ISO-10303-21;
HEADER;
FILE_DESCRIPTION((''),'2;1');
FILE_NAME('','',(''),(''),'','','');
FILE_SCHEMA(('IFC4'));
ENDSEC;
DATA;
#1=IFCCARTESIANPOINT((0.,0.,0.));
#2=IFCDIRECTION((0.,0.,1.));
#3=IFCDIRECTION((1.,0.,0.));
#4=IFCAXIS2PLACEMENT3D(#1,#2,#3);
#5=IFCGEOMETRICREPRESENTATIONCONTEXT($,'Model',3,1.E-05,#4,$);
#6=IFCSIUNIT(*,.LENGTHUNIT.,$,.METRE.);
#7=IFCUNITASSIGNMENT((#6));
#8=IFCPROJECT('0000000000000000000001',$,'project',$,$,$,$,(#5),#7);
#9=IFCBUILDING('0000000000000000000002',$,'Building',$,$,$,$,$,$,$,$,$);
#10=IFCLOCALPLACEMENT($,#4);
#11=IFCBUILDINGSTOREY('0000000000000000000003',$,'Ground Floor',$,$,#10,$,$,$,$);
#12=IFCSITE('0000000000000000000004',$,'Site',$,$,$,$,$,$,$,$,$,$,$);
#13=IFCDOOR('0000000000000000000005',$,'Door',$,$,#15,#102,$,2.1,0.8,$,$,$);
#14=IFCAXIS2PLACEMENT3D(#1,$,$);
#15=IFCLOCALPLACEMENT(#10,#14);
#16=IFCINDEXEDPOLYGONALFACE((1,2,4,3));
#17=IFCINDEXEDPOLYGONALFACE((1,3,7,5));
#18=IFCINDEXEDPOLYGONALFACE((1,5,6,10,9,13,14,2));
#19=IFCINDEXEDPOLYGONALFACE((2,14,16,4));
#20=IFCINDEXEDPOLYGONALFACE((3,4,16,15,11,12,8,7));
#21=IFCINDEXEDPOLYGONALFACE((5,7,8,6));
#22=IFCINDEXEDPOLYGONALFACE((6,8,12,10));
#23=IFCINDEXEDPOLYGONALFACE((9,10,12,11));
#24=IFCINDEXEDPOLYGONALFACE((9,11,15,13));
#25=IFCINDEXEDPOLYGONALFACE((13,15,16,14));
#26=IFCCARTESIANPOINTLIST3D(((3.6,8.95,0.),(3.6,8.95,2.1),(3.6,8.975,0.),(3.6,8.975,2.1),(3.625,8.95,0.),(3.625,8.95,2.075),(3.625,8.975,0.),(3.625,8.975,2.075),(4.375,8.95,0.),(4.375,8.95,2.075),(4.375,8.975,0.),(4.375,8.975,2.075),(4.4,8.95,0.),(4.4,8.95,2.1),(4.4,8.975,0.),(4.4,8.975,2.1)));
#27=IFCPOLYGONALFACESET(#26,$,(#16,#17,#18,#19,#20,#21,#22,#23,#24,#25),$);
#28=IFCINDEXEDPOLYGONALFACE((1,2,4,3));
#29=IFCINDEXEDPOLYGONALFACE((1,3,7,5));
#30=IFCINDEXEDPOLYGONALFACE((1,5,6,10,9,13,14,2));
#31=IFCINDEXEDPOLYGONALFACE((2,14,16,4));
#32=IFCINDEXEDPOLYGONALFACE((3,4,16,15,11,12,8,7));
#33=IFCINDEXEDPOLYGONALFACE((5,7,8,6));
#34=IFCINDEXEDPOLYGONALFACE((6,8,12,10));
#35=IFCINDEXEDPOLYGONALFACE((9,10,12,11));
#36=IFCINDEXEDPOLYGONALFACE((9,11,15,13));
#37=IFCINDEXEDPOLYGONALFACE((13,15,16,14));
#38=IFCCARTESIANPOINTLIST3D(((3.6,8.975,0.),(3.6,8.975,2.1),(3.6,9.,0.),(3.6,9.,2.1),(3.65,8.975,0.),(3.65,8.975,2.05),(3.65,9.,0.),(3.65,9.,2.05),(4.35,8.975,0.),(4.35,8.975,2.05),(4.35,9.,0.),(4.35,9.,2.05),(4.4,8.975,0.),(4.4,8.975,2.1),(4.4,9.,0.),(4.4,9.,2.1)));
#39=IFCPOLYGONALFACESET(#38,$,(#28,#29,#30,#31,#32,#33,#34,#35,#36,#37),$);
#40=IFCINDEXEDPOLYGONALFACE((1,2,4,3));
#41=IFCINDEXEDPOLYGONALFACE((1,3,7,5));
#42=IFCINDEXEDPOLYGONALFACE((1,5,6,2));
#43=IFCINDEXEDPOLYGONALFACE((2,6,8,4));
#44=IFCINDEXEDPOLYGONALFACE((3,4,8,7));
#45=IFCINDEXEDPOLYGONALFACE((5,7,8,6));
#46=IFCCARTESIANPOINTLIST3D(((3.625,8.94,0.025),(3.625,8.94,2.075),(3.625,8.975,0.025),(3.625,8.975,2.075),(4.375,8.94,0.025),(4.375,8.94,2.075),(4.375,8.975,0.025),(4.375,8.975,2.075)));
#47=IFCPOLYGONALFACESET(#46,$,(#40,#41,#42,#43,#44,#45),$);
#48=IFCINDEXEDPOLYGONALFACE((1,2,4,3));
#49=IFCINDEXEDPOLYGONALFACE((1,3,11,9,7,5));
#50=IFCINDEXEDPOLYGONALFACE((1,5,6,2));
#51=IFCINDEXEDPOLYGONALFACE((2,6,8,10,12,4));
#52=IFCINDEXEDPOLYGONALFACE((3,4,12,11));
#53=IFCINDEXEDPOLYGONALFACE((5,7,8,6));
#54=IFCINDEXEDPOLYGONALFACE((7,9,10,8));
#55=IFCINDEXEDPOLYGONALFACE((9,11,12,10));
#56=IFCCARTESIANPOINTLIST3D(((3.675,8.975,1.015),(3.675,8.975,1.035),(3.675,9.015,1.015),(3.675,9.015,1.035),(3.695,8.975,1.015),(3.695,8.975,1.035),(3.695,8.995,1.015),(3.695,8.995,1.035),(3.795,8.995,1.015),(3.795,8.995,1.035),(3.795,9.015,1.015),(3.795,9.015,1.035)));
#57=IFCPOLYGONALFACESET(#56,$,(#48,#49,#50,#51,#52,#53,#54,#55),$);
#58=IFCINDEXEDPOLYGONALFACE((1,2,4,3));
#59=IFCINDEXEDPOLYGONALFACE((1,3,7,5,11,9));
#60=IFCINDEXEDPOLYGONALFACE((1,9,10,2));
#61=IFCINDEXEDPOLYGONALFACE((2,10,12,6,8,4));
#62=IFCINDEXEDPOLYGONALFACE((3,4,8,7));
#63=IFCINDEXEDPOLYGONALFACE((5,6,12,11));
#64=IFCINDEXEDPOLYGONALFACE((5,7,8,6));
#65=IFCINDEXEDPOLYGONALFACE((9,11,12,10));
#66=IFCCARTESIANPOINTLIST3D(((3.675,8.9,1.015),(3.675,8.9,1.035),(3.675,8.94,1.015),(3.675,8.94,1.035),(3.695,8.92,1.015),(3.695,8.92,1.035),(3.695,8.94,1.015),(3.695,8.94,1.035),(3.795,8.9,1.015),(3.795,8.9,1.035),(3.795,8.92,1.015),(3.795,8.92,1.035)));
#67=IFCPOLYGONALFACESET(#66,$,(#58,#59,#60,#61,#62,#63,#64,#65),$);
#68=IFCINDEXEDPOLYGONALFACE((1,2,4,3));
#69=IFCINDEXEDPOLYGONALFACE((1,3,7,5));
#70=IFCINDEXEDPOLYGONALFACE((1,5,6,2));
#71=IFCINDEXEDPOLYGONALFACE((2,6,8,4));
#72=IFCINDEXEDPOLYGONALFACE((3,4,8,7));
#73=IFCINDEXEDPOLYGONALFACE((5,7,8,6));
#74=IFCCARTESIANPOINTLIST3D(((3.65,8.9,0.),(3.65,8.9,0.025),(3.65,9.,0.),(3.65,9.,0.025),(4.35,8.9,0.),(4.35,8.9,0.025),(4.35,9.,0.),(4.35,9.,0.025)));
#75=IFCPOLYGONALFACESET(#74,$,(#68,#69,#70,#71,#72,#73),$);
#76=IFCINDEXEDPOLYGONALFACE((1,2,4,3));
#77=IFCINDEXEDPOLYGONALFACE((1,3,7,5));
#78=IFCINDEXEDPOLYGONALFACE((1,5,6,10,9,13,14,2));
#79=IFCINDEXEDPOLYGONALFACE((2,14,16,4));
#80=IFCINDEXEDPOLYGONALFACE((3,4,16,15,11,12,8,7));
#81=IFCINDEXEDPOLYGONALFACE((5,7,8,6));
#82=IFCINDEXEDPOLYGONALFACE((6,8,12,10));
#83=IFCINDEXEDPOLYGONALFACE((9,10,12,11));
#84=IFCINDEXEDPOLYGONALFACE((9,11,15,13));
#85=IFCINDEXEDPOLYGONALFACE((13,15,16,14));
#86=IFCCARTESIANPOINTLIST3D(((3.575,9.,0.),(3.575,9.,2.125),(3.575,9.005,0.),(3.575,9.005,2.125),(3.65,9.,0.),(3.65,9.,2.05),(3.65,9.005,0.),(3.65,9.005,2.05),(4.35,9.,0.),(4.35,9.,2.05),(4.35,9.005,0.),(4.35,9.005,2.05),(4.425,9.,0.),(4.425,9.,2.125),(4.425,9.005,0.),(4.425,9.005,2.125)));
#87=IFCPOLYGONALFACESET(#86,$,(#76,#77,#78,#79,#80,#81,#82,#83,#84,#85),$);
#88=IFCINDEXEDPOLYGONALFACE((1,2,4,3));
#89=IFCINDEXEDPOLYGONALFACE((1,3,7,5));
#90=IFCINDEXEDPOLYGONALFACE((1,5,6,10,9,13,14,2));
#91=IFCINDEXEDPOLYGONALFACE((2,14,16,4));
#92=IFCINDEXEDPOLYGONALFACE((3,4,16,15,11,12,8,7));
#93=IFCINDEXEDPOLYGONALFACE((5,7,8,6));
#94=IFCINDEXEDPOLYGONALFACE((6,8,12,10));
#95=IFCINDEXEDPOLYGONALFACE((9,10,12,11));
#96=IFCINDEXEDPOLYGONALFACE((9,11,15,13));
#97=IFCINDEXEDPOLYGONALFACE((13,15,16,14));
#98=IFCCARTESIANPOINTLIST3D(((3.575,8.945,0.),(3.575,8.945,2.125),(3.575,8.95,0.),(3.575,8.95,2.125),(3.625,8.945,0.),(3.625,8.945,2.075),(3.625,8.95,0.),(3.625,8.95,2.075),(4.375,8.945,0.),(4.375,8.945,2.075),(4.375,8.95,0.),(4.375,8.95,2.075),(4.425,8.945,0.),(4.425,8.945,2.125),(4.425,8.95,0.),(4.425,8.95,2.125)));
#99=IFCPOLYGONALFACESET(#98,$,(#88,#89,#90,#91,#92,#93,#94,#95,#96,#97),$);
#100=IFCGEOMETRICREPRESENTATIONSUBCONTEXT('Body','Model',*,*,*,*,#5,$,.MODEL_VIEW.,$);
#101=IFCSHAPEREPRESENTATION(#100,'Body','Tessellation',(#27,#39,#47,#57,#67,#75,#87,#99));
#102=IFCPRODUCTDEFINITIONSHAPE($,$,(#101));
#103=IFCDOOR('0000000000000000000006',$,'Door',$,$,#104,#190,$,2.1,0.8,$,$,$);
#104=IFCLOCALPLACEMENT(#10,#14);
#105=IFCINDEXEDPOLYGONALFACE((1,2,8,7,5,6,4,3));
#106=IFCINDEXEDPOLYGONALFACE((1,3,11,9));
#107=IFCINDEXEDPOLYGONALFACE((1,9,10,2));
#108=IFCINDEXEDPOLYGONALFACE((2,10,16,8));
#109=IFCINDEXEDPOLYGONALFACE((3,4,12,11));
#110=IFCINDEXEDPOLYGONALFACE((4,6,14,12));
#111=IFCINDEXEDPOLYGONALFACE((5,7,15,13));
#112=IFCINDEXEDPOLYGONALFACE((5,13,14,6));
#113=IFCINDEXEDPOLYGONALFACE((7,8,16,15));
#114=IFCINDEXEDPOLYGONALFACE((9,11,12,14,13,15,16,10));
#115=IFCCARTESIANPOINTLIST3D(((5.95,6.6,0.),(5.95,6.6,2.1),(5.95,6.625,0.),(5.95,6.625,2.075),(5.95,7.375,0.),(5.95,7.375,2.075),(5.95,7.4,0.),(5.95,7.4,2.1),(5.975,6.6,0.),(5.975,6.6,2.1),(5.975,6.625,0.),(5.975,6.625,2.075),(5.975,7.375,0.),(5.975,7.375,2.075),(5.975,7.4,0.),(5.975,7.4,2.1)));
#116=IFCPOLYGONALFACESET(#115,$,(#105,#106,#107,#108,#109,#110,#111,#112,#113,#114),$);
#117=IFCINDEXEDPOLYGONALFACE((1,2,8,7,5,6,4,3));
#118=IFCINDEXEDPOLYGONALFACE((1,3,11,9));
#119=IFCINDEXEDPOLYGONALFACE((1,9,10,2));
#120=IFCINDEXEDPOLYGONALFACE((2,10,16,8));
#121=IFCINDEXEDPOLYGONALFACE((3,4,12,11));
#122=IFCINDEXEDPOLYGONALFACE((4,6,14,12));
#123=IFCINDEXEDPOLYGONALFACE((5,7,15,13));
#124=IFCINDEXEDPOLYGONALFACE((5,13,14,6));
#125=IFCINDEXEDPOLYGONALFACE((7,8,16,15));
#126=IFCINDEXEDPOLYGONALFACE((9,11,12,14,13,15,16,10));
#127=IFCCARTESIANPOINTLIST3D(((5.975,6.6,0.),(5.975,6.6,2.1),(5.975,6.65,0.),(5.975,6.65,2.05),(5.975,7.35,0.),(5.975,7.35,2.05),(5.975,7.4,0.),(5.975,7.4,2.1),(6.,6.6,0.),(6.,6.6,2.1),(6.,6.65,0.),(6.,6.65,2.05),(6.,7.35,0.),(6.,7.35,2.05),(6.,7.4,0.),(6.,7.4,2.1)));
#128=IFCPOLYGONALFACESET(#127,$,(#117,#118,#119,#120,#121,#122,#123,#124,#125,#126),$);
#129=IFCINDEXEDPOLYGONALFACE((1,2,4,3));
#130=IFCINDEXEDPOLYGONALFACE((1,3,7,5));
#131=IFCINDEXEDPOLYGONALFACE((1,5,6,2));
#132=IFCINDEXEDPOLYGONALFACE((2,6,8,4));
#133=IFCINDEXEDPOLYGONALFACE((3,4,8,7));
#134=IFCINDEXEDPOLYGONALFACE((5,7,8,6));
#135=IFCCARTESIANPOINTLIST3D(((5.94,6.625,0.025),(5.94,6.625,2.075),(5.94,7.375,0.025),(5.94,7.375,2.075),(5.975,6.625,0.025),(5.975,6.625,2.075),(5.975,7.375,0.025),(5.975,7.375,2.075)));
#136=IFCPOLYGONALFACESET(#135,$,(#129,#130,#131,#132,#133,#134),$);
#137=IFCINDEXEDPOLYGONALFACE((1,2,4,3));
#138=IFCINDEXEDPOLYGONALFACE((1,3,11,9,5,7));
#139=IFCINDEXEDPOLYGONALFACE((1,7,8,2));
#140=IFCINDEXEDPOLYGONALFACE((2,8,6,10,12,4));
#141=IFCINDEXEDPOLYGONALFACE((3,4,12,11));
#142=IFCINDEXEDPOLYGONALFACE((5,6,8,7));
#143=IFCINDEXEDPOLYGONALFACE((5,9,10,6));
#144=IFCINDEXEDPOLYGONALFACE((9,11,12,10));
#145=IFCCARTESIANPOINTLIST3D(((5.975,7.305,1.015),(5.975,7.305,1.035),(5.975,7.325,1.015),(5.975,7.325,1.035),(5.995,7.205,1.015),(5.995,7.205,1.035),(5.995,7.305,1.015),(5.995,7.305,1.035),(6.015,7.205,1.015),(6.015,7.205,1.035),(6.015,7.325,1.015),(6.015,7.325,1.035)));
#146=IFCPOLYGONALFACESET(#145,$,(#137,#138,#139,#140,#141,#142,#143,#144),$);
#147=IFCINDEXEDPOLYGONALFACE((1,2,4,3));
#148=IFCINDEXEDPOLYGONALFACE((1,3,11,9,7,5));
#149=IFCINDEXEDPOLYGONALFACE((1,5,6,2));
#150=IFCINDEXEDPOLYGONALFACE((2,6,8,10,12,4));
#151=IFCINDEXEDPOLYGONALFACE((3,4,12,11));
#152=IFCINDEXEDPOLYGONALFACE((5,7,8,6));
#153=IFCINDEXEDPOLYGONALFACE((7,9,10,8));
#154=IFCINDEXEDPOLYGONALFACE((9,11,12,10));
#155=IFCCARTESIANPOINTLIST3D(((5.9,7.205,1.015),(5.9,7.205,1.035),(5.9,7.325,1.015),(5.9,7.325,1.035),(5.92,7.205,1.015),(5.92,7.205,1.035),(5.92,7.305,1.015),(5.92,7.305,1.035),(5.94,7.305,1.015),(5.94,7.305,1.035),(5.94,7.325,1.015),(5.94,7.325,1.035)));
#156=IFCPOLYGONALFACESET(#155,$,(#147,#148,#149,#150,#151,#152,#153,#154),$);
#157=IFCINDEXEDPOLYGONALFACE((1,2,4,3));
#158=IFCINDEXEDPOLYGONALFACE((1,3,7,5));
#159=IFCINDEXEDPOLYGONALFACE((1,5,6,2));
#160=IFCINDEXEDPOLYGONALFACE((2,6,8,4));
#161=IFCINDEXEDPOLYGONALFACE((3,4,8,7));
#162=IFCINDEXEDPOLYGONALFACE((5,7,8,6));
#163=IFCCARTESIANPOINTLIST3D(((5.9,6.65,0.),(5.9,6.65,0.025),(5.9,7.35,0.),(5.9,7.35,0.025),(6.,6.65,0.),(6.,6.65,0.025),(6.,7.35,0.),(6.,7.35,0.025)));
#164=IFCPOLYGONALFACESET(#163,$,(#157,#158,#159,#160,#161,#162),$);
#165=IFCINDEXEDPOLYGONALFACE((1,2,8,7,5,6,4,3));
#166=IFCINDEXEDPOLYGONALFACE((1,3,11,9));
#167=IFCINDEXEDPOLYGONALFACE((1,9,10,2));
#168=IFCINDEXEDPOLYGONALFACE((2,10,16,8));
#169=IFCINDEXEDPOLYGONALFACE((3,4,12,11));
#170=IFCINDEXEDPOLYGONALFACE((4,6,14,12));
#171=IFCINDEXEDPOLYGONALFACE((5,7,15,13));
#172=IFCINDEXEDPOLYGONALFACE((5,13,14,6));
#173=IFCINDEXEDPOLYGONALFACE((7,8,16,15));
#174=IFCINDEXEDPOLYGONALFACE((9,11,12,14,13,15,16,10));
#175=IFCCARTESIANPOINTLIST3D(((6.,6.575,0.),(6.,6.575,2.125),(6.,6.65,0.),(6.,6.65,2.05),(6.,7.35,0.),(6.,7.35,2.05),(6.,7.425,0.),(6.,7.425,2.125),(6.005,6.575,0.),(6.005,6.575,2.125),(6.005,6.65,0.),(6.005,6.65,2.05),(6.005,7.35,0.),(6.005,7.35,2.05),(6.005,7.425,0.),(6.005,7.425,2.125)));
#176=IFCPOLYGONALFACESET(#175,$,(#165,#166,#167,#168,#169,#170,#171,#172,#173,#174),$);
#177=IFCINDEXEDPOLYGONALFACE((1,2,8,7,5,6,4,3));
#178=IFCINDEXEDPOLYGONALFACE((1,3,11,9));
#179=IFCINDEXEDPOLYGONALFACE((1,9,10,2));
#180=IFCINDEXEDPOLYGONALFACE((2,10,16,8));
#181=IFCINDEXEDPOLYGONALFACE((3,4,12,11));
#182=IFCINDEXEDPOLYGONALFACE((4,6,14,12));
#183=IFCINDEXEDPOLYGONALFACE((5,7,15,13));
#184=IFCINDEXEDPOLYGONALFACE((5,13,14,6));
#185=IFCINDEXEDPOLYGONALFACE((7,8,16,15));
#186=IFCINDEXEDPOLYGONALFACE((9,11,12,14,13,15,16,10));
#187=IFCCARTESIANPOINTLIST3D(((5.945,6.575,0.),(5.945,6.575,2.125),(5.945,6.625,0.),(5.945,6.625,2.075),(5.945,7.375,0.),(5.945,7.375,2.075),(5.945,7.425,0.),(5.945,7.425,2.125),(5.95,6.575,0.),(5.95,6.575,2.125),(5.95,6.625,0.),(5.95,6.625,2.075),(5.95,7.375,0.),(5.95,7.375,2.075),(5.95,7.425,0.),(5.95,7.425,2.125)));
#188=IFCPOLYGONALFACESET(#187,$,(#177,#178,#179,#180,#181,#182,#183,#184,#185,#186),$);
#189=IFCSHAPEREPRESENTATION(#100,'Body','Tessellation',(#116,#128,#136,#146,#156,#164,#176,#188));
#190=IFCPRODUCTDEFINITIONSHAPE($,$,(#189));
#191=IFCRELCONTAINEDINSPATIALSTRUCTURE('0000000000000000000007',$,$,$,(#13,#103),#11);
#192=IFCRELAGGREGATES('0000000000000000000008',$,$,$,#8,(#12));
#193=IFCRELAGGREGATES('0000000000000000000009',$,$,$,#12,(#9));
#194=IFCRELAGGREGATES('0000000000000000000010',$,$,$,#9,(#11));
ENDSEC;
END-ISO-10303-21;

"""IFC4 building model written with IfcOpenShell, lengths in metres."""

from ifc_helpers import new_model, si_unit, frame, origin_with_axes, place, context, subcontext, project, spatial, line, indexed_curve, outline, extrude, element, save


model = new_model("IFC4")

# Units and contexts
model_context = context("Model", 3, precision=1e-05, world=origin_with_axes())
body_context = subcontext(model_context, "Body", "Model", "MODEL_VIEW")
ifc_project = project(units=[si_unit("LENGTHUNIT", "METRE")], contexts=[model_context])

# Site, building, storey
site = spatial("IfcSite", under=ifc_project, Name="Site")
building = spatial("IfcBuilding", under=site, Name="Building")
storey_placement = place(None, origin_with_axes())
storey = spatial("IfcBuildingStorey", under=building, at=storey_placement, Name="Ground Floor")

# Doors
door_1_placement = place(storey_placement, frame((4.4, 9.0, 0.0), z_axis=(0.0, 0.0, 1.0), x_axis=(-1.0, 0.0, 0.0)))
element("IfcDoor", 1, at=door_1_placement, inside=storey, Name="Door", OverallHeight=2.1, OverallWidth=0.8, context=body_context, shape_type="SweptSolid", body=[
    extrude(outline(indexed_curve([(0.0, 0.0), (0.0, 2.1), (0.8, 2.1), (0.8, 0.0), (0.775, 0.0), (0.775, 2.075), (0.025, 2.075), (0.025, 0.0)], segments=[line(1, 2, 3, 4, 5, 6, 7, 8, 1)])), frame((0.0, 0.025, 0.0), z_axis=(0.0, -1.0, 0.0), x_axis=(1.0, 0.0, 0.0)), (0.0, 0.0, -1.0), 0.025),
    extrude(outline(indexed_curve([(0.0, 0.0), (0.0, 2.1), (0.8, 2.1), (0.8, 0.0), (0.75, 0.0), (0.75, 2.05), (0.05, 2.05), (0.05, 0.0)], segments=[line(1, 2, 3, 4, 5, 6, 7, 8, 1)])), frame((0.0, 0.0, 0.0), z_axis=(0.0, -1.0, 0.0), x_axis=(1.0, 0.0, 0.0)), (0.0, 0.0, -1.0), 0.025),
    extrude(outline(indexed_curve([(0.0, 0.0), (0.75, 0.0), (0.75, 0.035), (0.0, 0.035)], segments=[line(1, 2, 3, 4, 1)])), frame((0.025, 0.025, 0.025), z_axis=(0.0, 0.0, 1.0), x_axis=(1.0, 0.0, 0.0)), (0.0, 0.0, 1.0), 2.05),
    extrude(outline(indexed_curve([(0.0, 0.0), (0.0, -0.04), (-0.12, -0.04), (-0.12, -0.02), (-0.02, -0.02), (-0.02, 0.0)], segments=[line(1, 2, 3, 4, 5, 6, 1)])), frame((0.725, 0.025, 1.015), z_axis=(0.0, 0.0, 1.0), x_axis=(1.0, 0.0, 0.0)), (0.0, 0.0, 1.0), 0.02),
    extrude(outline(indexed_curve([(0.0, 0.0), (0.0, 0.04), (-0.12, 0.04), (-0.12, 0.02), (-0.02, 0.02), (-0.02, 0.0)], segments=[line(1, 2, 3, 4, 5, 6, 1)])), frame((0.725, 0.06, 1.015), z_axis=(0.0, 0.0, 1.0), x_axis=(1.0, 0.0, 0.0)), (0.0, 0.0, 1.0), 0.02),
    extrude(outline(indexed_curve([(0.0, 0.0), (0.7, 0.0), (0.7, 0.1), (0.0, 0.1)], segments=[line(1, 2, 3, 4, 1)])), frame((0.05, 0.0, 0.0), z_axis=(0.0, 0.0, 1.0), x_axis=(1.0, 0.0, 0.0)), (0.0, 0.0, 1.0), 0.025),
    extrude(outline(indexed_curve([(0.0, 0.0), (0.0, 2.125), (0.85, 2.125), (0.85, 0.0), (0.775, 0.0), (0.775, 2.05), (0.075, 2.05), (0.075, 0.0)], segments=[line(1, 2, 3, 4, 5, 6, 7, 8, 1)])), frame((-0.025, -0.005, 0.0), z_axis=(0.0, -1.0, 0.0), x_axis=(1.0, 0.0, 0.0)), (0.0, 0.0, -1.0), 0.005),
    extrude(outline(indexed_curve([(0.0, 0.0), (0.0, 2.125), (0.85, 2.125), (0.85, 0.0), (0.8, 0.0), (0.8, 2.075), (0.05, 2.075), (0.05, 0.0)], segments=[line(1, 2, 3, 4, 5, 6, 7, 8, 1)])), frame((-0.025, 0.05, 0.0), z_axis=(0.0, -1.0, 0.0), x_axis=(1.0, 0.0, 0.0)), (0.0, 0.0, -1.0), 0.005),
])
door_2_placement = place(storey_placement, frame((6.0, 6.6, 0.0), z_axis=(0.0, 0.0, 1.0), x_axis=(0.0, 1.0, 0.0)))
element("IfcDoor", 2, at=door_2_placement, inside=storey, Name="Door", OverallHeight=2.1, OverallWidth=0.8, context=body_context, shape_type="SweptSolid", body=[
    extrude(outline(indexed_curve([(0.0, 0.0), (0.0, 2.1), (0.8, 2.1), (0.8, 0.0), (0.775, 0.0), (0.775, 2.075), (0.025, 2.075), (0.025, 0.0)], segments=[line(1, 2, 3, 4, 5, 6, 7, 8, 1)])), frame((0.0, 0.025, 0.0), z_axis=(0.0, -1.0, 0.0), x_axis=(1.0, 0.0, 0.0)), (0.0, 0.0, -1.0), 0.025),
    extrude(outline(indexed_curve([(0.0, 0.0), (0.0, 2.1), (0.8, 2.1), (0.8, 0.0), (0.75, 0.0), (0.75, 2.05), (0.05, 2.05), (0.05, 0.0)], segments=[line(1, 2, 3, 4, 5, 6, 7, 8, 1)])), frame((0.0, 0.0, 0.0), z_axis=(0.0, -1.0, 0.0), x_axis=(1.0, 0.0, 0.0)), (0.0, 0.0, -1.0), 0.025),
    extrude(outline(indexed_curve([(0.0, 0.0), (0.75, 0.0), (0.75, 0.035), (0.0, 0.035)], segments=[line(1, 2, 3, 4, 1)])), frame((0.025, 0.025, 0.025), z_axis=(0.0, 0.0, 1.0), x_axis=(1.0, 0.0, 0.0)), (0.0, 0.0, 1.0), 2.05),
    extrude(outline(indexed_curve([(0.0, 0.0), (0.0, -0.04), (-0.12, -0.04), (-0.12, -0.02), (-0.02, -0.02), (-0.02, 0.0)], segments=[line(1, 2, 3, 4, 5, 6, 1)])), frame((0.725, 0.025, 1.015), z_axis=(0.0, 0.0, 1.0), x_axis=(1.0, 0.0, 0.0)), (0.0, 0.0, 1.0), 0.02),
    extrude(outline(indexed_curve([(0.0, 0.0), (0.0, 0.04), (-0.12, 0.04), (-0.12, 0.02), (-0.02, 0.02), (-0.02, 0.0)], segments=[line(1, 2, 3, 4, 5, 6, 1)])), frame((0.725, 0.06, 1.015), z_axis=(0.0, 0.0, 1.0), x_axis=(1.0, 0.0, 0.0)), (0.0, 0.0, 1.0), 0.02),
    extrude(outline(indexed_curve([(0.0, 0.0), (0.7, 0.0), (0.7, 0.1), (0.0, 0.1)], segments=[line(1, 2, 3, 4, 1)])), frame((0.05, 0.0, 0.0), z_axis=(0.0, 0.0, 1.0), x_axis=(1.0, 0.0, 0.0)), (0.0, 0.0, 1.0), 0.025),
    extrude(outline(indexed_curve([(0.0, 0.0), (0.0, 2.125), (0.85, 2.125), (0.85, 0.0), (0.775, 0.0), (0.775, 2.05), (0.075, 2.05), (0.075, 0.0)], segments=[line(1, 2, 3, 4, 5, 6, 7, 8, 1)])), frame((-0.025, -0.005, 0.0), z_axis=(0.0, -1.0, 0.0), x_axis=(1.0, 0.0, 0.0)), (0.0, 0.0, -1.0), 0.005),
    extrude(outline(indexed_curve([(0.0, 0.0), (0.0, 2.125), (0.85, 2.125), (0.85, 0.0), (0.8, 0.0), (0.8, 2.075), (0.05, 2.075), (0.05, 0.0)], segments=[line(1, 2, 3, 4, 5, 6, 7, 8, 1)])), frame((-0.025, 0.05, 0.0), z_axis=(0.0, -1.0, 0.0), x_axis=(1.0, 0.0, 0.0)), (0.0, 0.0, -1.0), 0.005),
])

save(model, "model.ifc")
